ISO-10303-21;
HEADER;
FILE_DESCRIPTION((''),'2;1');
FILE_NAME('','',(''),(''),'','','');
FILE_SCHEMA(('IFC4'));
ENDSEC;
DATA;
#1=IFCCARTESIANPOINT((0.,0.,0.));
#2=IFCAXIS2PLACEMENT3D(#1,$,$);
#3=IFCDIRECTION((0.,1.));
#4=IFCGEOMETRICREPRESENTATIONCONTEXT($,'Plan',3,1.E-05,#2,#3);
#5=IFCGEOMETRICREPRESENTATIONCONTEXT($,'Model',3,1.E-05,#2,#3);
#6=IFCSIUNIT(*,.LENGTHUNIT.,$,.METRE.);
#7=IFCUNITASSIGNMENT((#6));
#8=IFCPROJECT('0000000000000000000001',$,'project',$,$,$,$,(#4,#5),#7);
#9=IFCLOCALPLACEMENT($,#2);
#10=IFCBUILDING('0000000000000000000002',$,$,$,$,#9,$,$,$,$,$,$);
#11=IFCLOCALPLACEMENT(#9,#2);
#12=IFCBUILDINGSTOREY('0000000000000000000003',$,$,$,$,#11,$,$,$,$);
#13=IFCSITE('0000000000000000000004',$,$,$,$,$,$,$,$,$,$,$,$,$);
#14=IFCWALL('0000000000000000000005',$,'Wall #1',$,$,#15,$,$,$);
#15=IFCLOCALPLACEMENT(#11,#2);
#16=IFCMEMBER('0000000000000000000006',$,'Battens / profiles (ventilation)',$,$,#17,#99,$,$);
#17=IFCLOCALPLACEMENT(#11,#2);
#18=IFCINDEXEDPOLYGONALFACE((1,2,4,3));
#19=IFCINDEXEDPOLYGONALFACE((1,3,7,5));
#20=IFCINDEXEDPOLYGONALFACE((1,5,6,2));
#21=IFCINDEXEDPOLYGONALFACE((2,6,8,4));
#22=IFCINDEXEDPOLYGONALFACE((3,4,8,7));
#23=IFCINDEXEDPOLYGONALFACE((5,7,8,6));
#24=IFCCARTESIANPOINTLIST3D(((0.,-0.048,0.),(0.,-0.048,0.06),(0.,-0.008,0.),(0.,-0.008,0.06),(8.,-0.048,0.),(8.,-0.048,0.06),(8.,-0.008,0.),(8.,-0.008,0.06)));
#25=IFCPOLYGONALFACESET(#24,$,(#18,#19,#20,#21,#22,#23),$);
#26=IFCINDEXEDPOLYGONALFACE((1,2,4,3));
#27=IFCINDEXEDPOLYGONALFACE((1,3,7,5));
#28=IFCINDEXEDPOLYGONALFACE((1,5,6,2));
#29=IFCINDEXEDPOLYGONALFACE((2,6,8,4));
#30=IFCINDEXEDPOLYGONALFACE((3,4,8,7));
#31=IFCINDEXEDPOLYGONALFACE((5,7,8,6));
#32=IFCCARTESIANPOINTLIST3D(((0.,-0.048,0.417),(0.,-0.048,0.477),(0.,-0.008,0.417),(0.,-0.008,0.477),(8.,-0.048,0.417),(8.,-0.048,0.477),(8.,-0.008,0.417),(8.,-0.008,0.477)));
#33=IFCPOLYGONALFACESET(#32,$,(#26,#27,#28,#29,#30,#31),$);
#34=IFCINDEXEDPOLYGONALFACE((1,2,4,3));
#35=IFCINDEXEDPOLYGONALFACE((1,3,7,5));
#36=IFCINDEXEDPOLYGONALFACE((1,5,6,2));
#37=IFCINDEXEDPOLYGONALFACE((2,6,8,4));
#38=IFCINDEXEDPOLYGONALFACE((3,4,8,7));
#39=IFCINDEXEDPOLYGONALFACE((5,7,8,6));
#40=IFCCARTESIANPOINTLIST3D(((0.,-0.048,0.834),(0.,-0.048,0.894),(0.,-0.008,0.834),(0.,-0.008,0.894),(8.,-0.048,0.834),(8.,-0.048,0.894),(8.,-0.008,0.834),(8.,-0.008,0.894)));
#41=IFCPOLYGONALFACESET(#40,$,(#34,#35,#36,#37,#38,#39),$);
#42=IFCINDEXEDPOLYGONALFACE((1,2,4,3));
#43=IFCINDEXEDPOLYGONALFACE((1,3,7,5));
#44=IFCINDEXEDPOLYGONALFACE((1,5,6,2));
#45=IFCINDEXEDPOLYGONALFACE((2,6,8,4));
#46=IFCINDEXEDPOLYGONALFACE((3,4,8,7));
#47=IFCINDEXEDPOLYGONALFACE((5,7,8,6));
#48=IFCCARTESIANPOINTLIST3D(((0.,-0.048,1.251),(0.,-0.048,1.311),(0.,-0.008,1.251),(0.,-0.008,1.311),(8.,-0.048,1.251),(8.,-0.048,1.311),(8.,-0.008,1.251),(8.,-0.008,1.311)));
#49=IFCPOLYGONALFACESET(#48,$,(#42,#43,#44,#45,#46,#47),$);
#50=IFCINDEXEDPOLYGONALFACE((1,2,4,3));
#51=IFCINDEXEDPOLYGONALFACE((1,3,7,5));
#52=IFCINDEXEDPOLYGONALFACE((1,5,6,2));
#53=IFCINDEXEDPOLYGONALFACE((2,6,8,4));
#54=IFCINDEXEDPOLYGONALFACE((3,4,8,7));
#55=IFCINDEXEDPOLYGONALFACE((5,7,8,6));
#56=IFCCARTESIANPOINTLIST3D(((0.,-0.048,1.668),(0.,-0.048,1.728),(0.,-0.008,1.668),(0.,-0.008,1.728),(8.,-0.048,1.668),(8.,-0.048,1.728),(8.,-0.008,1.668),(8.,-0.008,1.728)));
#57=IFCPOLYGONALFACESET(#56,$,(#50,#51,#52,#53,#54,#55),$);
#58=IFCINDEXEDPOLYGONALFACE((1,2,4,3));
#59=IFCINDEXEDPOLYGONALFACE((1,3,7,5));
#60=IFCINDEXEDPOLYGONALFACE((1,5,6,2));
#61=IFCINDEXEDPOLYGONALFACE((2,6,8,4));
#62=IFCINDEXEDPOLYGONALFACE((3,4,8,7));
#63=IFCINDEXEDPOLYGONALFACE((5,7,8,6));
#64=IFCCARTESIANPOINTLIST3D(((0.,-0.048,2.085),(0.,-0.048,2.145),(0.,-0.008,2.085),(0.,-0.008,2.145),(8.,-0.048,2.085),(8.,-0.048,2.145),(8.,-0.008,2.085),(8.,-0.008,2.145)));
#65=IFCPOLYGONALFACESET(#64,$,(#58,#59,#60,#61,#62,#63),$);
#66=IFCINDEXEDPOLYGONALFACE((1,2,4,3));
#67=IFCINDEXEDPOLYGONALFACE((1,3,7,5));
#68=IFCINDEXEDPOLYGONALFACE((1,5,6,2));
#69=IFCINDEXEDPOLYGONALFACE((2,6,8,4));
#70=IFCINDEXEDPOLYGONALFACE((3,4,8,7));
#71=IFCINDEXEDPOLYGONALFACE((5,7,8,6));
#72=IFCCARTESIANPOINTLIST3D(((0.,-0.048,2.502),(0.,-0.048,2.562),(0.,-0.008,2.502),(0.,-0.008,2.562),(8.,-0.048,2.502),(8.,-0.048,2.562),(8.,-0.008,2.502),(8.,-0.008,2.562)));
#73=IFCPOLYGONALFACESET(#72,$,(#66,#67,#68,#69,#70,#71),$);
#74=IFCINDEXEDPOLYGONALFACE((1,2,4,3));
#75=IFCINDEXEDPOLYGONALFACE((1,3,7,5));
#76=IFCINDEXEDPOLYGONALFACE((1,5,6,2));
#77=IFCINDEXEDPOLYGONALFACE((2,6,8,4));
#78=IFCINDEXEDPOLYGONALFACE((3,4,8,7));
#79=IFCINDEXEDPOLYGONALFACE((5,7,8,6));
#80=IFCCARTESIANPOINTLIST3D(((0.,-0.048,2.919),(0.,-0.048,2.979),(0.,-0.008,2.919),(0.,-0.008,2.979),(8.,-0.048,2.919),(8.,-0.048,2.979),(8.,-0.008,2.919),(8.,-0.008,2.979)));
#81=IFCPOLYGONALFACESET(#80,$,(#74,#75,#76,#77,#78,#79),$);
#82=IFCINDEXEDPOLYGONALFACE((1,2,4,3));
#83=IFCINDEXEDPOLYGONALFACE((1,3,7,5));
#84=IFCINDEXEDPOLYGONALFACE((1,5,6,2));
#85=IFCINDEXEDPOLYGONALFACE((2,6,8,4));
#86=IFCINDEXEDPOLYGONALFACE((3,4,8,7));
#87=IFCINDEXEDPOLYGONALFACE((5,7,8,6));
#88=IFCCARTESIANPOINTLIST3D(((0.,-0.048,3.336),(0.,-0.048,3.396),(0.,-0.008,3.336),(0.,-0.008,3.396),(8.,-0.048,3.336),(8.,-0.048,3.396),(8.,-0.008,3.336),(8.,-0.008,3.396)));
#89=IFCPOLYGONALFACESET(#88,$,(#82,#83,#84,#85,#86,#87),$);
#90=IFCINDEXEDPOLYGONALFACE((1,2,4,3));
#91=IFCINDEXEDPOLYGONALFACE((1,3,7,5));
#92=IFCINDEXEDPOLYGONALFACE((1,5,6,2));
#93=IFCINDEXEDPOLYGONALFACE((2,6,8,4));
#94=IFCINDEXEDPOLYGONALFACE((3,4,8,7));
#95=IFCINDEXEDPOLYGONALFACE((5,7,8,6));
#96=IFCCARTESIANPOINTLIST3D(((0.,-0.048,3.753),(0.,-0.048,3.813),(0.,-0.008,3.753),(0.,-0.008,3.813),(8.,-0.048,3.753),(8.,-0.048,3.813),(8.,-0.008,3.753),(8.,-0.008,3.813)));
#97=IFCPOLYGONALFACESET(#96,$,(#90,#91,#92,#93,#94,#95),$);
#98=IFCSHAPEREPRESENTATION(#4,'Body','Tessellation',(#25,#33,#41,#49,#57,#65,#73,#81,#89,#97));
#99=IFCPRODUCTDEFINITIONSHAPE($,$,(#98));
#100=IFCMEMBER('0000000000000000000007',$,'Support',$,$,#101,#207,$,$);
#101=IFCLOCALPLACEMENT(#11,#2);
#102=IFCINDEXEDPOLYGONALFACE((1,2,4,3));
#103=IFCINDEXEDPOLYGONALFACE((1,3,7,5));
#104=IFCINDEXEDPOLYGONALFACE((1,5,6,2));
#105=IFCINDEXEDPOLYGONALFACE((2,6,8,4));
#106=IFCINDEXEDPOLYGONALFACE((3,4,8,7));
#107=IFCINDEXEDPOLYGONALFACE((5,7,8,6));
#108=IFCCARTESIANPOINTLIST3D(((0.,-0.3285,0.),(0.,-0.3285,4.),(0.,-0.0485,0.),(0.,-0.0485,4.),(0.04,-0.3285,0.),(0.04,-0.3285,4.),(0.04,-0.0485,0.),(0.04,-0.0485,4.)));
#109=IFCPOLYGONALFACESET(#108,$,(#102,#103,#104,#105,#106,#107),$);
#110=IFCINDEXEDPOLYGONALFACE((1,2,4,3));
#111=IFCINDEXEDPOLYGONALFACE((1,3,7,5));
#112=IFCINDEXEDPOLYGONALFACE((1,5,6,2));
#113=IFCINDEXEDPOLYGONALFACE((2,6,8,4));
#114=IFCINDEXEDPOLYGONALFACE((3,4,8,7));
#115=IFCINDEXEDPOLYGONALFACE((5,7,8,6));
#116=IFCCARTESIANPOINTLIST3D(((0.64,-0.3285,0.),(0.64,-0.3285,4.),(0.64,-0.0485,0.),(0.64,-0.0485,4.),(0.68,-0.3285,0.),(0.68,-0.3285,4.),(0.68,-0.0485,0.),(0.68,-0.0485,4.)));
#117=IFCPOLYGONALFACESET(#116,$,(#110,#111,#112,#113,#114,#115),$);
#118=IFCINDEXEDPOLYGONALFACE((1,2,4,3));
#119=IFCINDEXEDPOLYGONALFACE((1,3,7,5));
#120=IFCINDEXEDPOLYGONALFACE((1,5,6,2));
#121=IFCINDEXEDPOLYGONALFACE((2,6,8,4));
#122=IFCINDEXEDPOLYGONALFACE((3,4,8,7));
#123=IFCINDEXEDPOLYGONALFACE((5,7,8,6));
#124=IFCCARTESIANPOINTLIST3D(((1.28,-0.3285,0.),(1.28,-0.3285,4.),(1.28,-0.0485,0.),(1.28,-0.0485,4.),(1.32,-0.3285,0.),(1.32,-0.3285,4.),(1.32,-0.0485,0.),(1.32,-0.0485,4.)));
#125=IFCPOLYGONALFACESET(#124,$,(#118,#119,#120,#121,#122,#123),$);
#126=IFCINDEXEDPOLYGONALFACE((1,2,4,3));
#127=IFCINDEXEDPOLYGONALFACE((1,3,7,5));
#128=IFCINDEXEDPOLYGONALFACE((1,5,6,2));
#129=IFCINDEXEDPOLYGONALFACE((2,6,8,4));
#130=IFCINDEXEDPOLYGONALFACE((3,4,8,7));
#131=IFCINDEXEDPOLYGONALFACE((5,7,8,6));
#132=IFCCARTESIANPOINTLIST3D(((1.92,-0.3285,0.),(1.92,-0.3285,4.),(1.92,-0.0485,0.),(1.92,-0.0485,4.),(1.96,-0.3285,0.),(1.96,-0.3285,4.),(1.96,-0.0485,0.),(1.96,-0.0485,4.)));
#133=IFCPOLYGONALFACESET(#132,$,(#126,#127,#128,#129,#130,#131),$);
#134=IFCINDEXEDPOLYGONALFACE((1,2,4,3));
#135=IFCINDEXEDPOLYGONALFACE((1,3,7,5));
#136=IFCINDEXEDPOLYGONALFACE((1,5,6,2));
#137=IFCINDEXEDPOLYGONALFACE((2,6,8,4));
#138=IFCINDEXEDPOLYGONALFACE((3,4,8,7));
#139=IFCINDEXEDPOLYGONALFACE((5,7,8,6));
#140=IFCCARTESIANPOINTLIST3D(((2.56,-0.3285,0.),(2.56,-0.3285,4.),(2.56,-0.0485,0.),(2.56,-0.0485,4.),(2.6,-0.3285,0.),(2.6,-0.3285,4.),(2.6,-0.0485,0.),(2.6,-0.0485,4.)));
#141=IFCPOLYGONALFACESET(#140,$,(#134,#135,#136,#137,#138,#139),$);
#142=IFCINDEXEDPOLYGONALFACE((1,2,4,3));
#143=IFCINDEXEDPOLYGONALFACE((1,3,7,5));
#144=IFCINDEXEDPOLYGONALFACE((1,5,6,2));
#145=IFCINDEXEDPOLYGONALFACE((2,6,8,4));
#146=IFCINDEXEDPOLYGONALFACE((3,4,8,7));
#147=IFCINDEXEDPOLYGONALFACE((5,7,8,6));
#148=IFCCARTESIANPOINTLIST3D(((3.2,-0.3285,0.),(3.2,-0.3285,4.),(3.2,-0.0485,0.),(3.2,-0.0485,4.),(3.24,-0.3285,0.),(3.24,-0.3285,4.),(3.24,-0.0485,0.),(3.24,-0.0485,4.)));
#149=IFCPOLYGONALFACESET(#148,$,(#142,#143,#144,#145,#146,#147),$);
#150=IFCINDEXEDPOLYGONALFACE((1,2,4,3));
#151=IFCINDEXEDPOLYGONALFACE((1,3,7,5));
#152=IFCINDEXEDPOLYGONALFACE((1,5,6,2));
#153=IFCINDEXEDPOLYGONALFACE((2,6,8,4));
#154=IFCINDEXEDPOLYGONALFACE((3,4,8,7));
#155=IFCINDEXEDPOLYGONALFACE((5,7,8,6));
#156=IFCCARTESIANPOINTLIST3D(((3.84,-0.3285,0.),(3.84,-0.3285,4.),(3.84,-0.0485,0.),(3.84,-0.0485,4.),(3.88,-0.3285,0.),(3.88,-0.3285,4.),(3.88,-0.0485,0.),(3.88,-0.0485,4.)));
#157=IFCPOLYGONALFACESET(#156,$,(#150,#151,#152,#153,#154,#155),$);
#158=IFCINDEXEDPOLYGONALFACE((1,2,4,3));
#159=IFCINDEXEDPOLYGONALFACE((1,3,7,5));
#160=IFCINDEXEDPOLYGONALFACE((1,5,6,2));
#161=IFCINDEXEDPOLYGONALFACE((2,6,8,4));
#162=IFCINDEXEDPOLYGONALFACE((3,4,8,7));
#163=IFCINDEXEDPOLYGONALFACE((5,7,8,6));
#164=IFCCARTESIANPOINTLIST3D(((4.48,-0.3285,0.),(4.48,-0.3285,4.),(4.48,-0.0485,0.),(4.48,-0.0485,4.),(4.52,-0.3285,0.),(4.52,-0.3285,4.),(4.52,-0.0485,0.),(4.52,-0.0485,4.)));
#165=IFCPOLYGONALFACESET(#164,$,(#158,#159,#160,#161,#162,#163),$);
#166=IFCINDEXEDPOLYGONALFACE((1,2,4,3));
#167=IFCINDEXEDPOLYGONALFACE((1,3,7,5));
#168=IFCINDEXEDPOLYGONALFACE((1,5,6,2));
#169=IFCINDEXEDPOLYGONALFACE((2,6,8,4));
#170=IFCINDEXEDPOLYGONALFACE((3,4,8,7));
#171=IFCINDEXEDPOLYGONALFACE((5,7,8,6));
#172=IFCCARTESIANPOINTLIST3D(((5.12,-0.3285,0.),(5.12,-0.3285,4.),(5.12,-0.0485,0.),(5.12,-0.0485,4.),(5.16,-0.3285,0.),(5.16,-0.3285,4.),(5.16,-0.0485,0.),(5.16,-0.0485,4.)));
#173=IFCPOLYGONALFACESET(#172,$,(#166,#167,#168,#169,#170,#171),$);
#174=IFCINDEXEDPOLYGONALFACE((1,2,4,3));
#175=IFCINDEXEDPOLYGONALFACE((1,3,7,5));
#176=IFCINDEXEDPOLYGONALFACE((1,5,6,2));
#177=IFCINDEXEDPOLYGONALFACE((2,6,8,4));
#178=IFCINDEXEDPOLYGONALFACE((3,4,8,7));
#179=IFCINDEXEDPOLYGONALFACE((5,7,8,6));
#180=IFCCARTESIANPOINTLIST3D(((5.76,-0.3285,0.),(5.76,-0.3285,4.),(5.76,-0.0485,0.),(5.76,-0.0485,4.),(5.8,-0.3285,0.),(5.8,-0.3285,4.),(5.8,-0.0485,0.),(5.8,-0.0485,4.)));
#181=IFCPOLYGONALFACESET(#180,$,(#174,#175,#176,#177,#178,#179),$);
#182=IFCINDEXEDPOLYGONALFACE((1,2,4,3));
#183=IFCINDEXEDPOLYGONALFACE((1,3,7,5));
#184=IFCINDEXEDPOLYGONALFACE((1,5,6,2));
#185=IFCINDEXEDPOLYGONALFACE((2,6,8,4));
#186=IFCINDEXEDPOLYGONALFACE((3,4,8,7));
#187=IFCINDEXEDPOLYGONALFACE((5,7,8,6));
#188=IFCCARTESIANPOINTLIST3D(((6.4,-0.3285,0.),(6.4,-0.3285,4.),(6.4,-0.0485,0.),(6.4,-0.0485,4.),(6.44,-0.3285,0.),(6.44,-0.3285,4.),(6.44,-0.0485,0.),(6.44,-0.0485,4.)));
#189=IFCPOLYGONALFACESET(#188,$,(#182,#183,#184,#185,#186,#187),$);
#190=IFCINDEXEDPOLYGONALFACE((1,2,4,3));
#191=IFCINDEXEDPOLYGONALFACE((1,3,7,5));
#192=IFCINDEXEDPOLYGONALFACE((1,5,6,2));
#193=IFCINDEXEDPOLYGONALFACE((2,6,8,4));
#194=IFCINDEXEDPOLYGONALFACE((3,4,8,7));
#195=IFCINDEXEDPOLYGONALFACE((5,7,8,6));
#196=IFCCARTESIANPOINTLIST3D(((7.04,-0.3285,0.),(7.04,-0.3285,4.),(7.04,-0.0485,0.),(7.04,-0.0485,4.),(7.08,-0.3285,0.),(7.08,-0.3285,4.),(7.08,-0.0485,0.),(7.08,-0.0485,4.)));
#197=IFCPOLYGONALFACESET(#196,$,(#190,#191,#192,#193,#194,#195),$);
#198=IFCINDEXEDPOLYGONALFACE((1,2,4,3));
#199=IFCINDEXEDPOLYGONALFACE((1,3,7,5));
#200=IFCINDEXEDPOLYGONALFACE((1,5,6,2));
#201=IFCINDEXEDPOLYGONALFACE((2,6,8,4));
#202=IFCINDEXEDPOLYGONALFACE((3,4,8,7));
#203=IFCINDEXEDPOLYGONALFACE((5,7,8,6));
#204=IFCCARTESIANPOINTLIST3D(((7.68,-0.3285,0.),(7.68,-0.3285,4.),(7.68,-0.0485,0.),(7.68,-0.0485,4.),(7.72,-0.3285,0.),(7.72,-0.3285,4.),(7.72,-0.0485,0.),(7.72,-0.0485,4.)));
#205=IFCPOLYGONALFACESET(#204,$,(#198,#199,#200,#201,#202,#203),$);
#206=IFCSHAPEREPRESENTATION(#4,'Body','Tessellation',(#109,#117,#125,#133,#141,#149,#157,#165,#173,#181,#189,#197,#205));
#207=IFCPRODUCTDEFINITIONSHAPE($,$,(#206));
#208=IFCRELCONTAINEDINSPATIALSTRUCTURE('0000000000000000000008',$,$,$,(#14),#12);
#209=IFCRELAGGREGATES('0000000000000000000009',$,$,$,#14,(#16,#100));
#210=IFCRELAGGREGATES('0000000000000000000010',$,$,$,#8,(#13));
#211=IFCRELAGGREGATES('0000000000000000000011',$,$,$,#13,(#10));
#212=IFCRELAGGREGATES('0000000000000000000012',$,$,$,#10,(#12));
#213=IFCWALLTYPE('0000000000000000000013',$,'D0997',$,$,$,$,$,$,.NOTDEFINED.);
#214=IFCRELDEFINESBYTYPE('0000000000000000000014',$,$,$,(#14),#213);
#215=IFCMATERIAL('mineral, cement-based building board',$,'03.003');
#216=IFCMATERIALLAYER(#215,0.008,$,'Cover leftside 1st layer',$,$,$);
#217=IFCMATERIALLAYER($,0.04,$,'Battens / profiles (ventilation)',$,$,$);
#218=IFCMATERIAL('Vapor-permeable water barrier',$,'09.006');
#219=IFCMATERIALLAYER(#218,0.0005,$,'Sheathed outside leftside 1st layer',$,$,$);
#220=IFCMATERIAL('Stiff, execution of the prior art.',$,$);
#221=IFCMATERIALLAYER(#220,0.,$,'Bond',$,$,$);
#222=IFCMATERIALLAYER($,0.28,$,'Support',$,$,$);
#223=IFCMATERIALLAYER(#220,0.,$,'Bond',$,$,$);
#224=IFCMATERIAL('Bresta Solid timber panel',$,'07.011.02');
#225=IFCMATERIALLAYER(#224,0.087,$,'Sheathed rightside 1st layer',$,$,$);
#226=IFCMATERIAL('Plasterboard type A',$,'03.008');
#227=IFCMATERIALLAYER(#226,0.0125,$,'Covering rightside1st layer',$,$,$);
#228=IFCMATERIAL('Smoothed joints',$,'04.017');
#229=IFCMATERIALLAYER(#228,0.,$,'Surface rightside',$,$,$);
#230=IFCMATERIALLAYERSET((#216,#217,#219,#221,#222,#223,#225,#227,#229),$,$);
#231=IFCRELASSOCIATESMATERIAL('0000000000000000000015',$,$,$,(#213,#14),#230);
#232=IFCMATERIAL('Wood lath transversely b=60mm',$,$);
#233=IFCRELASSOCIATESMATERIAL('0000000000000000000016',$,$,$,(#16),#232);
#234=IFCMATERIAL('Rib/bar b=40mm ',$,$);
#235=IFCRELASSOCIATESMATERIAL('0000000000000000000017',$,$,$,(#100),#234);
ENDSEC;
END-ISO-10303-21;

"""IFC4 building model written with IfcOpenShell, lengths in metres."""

from ifc_helpers import new_model, si_unit, direction, frame, frame_2d, origin, place, context, project, spatial, rectangle, extrude, material, layer, layer_set, type_object, element, aggregate, save


model = new_model("IFC4")

# Units and contexts
plan_context = context("Plan", 3, precision=1e-05, world=origin(), true_north=direction((0.0, 1.0)))
model_context = context("Model", 3, precision=1e-05, world=origin(), true_north=direction((0.0, 1.0)))
ifc_project = project(units=[si_unit("LENGTHUNIT", "METRE")], contexts=[plan_context, model_context])

# Site, building, storey
site = spatial("IfcSite", under=ifc_project)
building_placement = place(None, origin())
building = spatial("IfcBuilding", under=site, at=building_placement)
storey_placement = place(building_placement, origin())
storey = spatial("IfcBuildingStorey", under=building, at=storey_placement)

# Wall, members
ifc_material_1 = material(Name="mineral, cement-based building board", Category="03.003")
ifc_layer_1 = layer(ifc_material_1, 0.008, Name="Cover leftside 1st layer")
ifc_layer_2 = layer(None, 0.04, Name="Battens / profiles (ventilation)")
ifc_material_2 = material(Name="Vapor-permeable water barrier", Category="09.006")
ifc_layer_3 = layer(ifc_material_2, 0.0005, Name="Sheathed outside leftside 1st layer")
ifc_material_3 = material(Name="Stiff, execution of the prior art.")
ifc_layer_4 = layer(ifc_material_3, 0.0, Name="Bond")
ifc_layer_5 = layer(None, 0.28, Name="Support")
ifc_layer_6 = layer(ifc_material_3, 0.0, Name="Bond")
ifc_material_4 = material(Name="Bresta Solid timber panel", Category="07.011.02")
ifc_layer_7 = layer(ifc_material_4, 0.087, Name="Sheathed rightside 1st layer")
ifc_material_5 = material(Name="Plasterboard type A", Category="03.008")
ifc_layer_8 = layer(ifc_material_5, 0.0125, Name="Covering rightside1st layer")
ifc_material_6 = material(Name="Smoothed joints", Category="04.017")
ifc_layer_9 = layer(ifc_material_6, 0.0, Name="Surface rightside")
ifc_layer_set = layer_set([ifc_layer_1, ifc_layer_2, ifc_layer_3, ifc_layer_4, ifc_layer_5, ifc_layer_6, ifc_layer_7, ifc_layer_8, ifc_layer_9])
wall_type = type_object("IfcWallType", Name="D0997", PredefinedType="NOTDEFINED", material=ifc_layer_set)
wall_placement = place(None, frame((0.0, 0.0, 0.0), z_axis=(0.0, -1.0, 0.0), x_axis=(1.0, 0.0, 0.0)))
wall = element("IfcWall", 1, at=wall_placement, inside=storey, type_object=wall_type, material=ifc_layer_set, Name="Wall #1")
ifc_material_7 = material(Name="Wood lath transversely b=60mm")
member_1_placement = place(wall_placement, origin())
member_1 = element("IfcMember", 2, at=member_1_placement, material=ifc_material_7, Name="Battens / profiles (ventilation)", context=plan_context, shape_type="SweptSolid", body=[
    extrude(rectangle(XDim=0.06, YDim=0.04, at=frame_2d((0.03, 0.02), x_axis=(1.0, 0.0))), frame((0.0, 0.0, 0.008), z_axis=(1.0, 0.0, 0.0), x_axis=(0.0, 1.0, 0.0)), (0.0, 0.0, 1.0), 8.0),
    extrude(rectangle(XDim=0.06, YDim=0.04, at=frame_2d((0.03, 0.02), x_axis=(1.0, 0.0))), frame((0.0, 0.417, 0.008), z_axis=(1.0, 0.0, 0.0), x_axis=(0.0, 1.0, 0.0)), (0.0, 0.0, 1.0), 8.0),
    extrude(rectangle(XDim=0.06, YDim=0.04, at=frame_2d((0.03, 0.02), x_axis=(1.0, 0.0))), frame((0.0, 0.834, 0.008), z_axis=(1.0, 0.0, 0.0), x_axis=(0.0, 1.0, 0.0)), (0.0, 0.0, 1.0), 8.0),
    extrude(rectangle(XDim=0.06, YDim=0.04, at=frame_2d((0.03, 0.02), x_axis=(1.0, 0.0))), frame((0.0, 1.251, 0.008), z_axis=(1.0, 0.0, 0.0), x_axis=(0.0, 1.0, 0.0)), (0.0, 0.0, 1.0), 8.0),
    extrude(rectangle(XDim=0.06, YDim=0.04, at=frame_2d((0.03, 0.02), x_axis=(1.0, 0.0))), frame((0.0, 1.668, 0.008), z_axis=(1.0, 0.0, 0.0), x_axis=(0.0, 1.0, 0.0)), (0.0, 0.0, 1.0), 8.0),
    extrude(rectangle(XDim=0.06, YDim=0.04, at=frame_2d((0.03, 0.02), x_axis=(1.0, 0.0))), frame((0.0, 2.085, 0.008), z_axis=(1.0, 0.0, 0.0), x_axis=(0.0, 1.0, 0.0)), (0.0, 0.0, 1.0), 8.0),
    extrude(rectangle(XDim=0.06, YDim=0.04, at=frame_2d((0.03, 0.02), x_axis=(1.0, 0.0))), frame((0.0, 2.502, 0.008), z_axis=(1.0, 0.0, 0.0), x_axis=(0.0, 1.0, 0.0)), (0.0, 0.0, 1.0), 8.0),
    extrude(rectangle(XDim=0.06, YDim=0.04, at=frame_2d((0.03, 0.02), x_axis=(1.0, 0.0))), frame((0.0, 2.919, 0.008), z_axis=(1.0, 0.0, 0.0), x_axis=(0.0, 1.0, 0.0)), (0.0, 0.0, 1.0), 8.0),
    extrude(rectangle(XDim=0.06, YDim=0.04, at=frame_2d((0.03, 0.02), x_axis=(1.0, 0.0))), frame((0.0, 3.336, 0.008), z_axis=(1.0, 0.0, 0.0), x_axis=(0.0, 1.0, 0.0)), (0.0, 0.0, 1.0), 8.0),
    extrude(rectangle(XDim=0.06, YDim=0.04, at=frame_2d((0.03, 0.02), x_axis=(1.0, 0.0))), frame((0.0, 3.753, 0.008), z_axis=(1.0, 0.0, 0.0), x_axis=(0.0, 1.0, 0.0)), (0.0, 0.0, 1.0), 8.0),
])
ifc_material_8 = material(Name="Rib/bar b=40mm ")
member_2_placement = place(wall_placement, origin())
member_2 = element("IfcMember", 3, at=member_2_placement, material=ifc_material_8, Name="Support", context=plan_context, shape_type="SweptSolid", body=[
    extrude(rectangle(XDim=0.04, YDim=0.28, at=frame_2d((0.02, 0.14), x_axis=(1.0, 0.0))), frame((0.0, 4.0, 0.0485), z_axis=(0.0, -1.0, 0.0), x_axis=(1.0, 0.0, 0.0)), (0.0, 0.0, 1.0), 4.0),
    extrude(rectangle(XDim=0.04, YDim=0.28, at=frame_2d((0.02, 0.14), x_axis=(1.0, 0.0))), frame((0.64, 4.0, 0.0485), z_axis=(0.0, -1.0, 0.0), x_axis=(1.0, 0.0, 0.0)), (0.0, 0.0, 1.0), 4.0),
    extrude(rectangle(XDim=0.04, YDim=0.28, at=frame_2d((0.02, 0.14), x_axis=(1.0, 0.0))), frame((1.28, 4.0, 0.0485), z_axis=(0.0, -1.0, 0.0), x_axis=(1.0, 0.0, 0.0)), (0.0, 0.0, 1.0), 4.0),
    extrude(rectangle(XDim=0.04, YDim=0.28, at=frame_2d((0.02, 0.14), x_axis=(1.0, 0.0))), frame((1.92, 4.0, 0.0485), z_axis=(0.0, -1.0, 0.0), x_axis=(1.0, 0.0, 0.0)), (0.0, 0.0, 1.0), 4.0),
    extrude(rectangle(XDim=0.04, YDim=0.28, at=frame_2d((0.02, 0.14), x_axis=(1.0, 0.0))), frame((2.56, 4.0, 0.0485), z_axis=(0.0, -1.0, 0.0), x_axis=(1.0, 0.0, 0.0)), (0.0, 0.0, 1.0), 4.0),
    extrude(rectangle(XDim=0.04, YDim=0.28, at=frame_2d((0.02, 0.14), x_axis=(1.0, 0.0))), frame((3.2, 4.0, 0.0485), z_axis=(0.0, -1.0, 0.0), x_axis=(1.0, 0.0, 0.0)), (0.0, 0.0, 1.0), 4.0),
    extrude(rectangle(XDim=0.04, YDim=0.28, at=frame_2d((0.02, 0.14), x_axis=(1.0, 0.0))), frame((3.84, 4.0, 0.0485), z_axis=(0.0, -1.0, 0.0), x_axis=(1.0, 0.0, 0.0)), (0.0, 0.0, 1.0), 4.0),
    extrude(rectangle(XDim=0.04, YDim=0.28, at=frame_2d((0.02, 0.14), x_axis=(1.0, 0.0))), frame((4.48, 4.0, 0.0485), z_axis=(0.0, -1.0, 0.0), x_axis=(1.0, 0.0, 0.0)), (0.0, 0.0, 1.0), 4.0),
    extrude(rectangle(XDim=0.04, YDim=0.28, at=frame_2d((0.02, 0.14), x_axis=(1.0, 0.0))), frame((5.12, 4.0, 0.0485), z_axis=(0.0, -1.0, 0.0), x_axis=(1.0, 0.0, 0.0)), (0.0, 0.0, 1.0), 4.0),
    extrude(rectangle(XDim=0.04, YDim=0.28, at=frame_2d((0.02, 0.14), x_axis=(1.0, 0.0))), frame((5.76, 4.0, 0.0485), z_axis=(0.0, -1.0, 0.0), x_axis=(1.0, 0.0, 0.0)), (0.0, 0.0, 1.0), 4.0),
    extrude(rectangle(XDim=0.04, YDim=0.28, at=frame_2d((0.02, 0.14), x_axis=(1.0, 0.0))), frame((6.4, 4.0, 0.0485), z_axis=(0.0, -1.0, 0.0), x_axis=(1.0, 0.0, 0.0)), (0.0, 0.0, 1.0), 4.0),
    extrude(rectangle(XDim=0.04, YDim=0.28, at=frame_2d((0.02, 0.14), x_axis=(1.0, 0.0))), frame((7.04, 4.0, 0.0485), z_axis=(0.0, -1.0, 0.0), x_axis=(1.0, 0.0, 0.0)), (0.0, 0.0, 1.0), 4.0),
    extrude(rectangle(XDim=0.04, YDim=0.28, at=frame_2d((0.02, 0.14), x_axis=(1.0, 0.0))), frame((7.68, 4.0, 0.0485), z_axis=(0.0, -1.0, 0.0), x_axis=(1.0, 0.0, 0.0)), (0.0, 0.0, 1.0), 4.0),
])
aggregate(wall, [member_1, member_2])

save(model, "model.ifc")
